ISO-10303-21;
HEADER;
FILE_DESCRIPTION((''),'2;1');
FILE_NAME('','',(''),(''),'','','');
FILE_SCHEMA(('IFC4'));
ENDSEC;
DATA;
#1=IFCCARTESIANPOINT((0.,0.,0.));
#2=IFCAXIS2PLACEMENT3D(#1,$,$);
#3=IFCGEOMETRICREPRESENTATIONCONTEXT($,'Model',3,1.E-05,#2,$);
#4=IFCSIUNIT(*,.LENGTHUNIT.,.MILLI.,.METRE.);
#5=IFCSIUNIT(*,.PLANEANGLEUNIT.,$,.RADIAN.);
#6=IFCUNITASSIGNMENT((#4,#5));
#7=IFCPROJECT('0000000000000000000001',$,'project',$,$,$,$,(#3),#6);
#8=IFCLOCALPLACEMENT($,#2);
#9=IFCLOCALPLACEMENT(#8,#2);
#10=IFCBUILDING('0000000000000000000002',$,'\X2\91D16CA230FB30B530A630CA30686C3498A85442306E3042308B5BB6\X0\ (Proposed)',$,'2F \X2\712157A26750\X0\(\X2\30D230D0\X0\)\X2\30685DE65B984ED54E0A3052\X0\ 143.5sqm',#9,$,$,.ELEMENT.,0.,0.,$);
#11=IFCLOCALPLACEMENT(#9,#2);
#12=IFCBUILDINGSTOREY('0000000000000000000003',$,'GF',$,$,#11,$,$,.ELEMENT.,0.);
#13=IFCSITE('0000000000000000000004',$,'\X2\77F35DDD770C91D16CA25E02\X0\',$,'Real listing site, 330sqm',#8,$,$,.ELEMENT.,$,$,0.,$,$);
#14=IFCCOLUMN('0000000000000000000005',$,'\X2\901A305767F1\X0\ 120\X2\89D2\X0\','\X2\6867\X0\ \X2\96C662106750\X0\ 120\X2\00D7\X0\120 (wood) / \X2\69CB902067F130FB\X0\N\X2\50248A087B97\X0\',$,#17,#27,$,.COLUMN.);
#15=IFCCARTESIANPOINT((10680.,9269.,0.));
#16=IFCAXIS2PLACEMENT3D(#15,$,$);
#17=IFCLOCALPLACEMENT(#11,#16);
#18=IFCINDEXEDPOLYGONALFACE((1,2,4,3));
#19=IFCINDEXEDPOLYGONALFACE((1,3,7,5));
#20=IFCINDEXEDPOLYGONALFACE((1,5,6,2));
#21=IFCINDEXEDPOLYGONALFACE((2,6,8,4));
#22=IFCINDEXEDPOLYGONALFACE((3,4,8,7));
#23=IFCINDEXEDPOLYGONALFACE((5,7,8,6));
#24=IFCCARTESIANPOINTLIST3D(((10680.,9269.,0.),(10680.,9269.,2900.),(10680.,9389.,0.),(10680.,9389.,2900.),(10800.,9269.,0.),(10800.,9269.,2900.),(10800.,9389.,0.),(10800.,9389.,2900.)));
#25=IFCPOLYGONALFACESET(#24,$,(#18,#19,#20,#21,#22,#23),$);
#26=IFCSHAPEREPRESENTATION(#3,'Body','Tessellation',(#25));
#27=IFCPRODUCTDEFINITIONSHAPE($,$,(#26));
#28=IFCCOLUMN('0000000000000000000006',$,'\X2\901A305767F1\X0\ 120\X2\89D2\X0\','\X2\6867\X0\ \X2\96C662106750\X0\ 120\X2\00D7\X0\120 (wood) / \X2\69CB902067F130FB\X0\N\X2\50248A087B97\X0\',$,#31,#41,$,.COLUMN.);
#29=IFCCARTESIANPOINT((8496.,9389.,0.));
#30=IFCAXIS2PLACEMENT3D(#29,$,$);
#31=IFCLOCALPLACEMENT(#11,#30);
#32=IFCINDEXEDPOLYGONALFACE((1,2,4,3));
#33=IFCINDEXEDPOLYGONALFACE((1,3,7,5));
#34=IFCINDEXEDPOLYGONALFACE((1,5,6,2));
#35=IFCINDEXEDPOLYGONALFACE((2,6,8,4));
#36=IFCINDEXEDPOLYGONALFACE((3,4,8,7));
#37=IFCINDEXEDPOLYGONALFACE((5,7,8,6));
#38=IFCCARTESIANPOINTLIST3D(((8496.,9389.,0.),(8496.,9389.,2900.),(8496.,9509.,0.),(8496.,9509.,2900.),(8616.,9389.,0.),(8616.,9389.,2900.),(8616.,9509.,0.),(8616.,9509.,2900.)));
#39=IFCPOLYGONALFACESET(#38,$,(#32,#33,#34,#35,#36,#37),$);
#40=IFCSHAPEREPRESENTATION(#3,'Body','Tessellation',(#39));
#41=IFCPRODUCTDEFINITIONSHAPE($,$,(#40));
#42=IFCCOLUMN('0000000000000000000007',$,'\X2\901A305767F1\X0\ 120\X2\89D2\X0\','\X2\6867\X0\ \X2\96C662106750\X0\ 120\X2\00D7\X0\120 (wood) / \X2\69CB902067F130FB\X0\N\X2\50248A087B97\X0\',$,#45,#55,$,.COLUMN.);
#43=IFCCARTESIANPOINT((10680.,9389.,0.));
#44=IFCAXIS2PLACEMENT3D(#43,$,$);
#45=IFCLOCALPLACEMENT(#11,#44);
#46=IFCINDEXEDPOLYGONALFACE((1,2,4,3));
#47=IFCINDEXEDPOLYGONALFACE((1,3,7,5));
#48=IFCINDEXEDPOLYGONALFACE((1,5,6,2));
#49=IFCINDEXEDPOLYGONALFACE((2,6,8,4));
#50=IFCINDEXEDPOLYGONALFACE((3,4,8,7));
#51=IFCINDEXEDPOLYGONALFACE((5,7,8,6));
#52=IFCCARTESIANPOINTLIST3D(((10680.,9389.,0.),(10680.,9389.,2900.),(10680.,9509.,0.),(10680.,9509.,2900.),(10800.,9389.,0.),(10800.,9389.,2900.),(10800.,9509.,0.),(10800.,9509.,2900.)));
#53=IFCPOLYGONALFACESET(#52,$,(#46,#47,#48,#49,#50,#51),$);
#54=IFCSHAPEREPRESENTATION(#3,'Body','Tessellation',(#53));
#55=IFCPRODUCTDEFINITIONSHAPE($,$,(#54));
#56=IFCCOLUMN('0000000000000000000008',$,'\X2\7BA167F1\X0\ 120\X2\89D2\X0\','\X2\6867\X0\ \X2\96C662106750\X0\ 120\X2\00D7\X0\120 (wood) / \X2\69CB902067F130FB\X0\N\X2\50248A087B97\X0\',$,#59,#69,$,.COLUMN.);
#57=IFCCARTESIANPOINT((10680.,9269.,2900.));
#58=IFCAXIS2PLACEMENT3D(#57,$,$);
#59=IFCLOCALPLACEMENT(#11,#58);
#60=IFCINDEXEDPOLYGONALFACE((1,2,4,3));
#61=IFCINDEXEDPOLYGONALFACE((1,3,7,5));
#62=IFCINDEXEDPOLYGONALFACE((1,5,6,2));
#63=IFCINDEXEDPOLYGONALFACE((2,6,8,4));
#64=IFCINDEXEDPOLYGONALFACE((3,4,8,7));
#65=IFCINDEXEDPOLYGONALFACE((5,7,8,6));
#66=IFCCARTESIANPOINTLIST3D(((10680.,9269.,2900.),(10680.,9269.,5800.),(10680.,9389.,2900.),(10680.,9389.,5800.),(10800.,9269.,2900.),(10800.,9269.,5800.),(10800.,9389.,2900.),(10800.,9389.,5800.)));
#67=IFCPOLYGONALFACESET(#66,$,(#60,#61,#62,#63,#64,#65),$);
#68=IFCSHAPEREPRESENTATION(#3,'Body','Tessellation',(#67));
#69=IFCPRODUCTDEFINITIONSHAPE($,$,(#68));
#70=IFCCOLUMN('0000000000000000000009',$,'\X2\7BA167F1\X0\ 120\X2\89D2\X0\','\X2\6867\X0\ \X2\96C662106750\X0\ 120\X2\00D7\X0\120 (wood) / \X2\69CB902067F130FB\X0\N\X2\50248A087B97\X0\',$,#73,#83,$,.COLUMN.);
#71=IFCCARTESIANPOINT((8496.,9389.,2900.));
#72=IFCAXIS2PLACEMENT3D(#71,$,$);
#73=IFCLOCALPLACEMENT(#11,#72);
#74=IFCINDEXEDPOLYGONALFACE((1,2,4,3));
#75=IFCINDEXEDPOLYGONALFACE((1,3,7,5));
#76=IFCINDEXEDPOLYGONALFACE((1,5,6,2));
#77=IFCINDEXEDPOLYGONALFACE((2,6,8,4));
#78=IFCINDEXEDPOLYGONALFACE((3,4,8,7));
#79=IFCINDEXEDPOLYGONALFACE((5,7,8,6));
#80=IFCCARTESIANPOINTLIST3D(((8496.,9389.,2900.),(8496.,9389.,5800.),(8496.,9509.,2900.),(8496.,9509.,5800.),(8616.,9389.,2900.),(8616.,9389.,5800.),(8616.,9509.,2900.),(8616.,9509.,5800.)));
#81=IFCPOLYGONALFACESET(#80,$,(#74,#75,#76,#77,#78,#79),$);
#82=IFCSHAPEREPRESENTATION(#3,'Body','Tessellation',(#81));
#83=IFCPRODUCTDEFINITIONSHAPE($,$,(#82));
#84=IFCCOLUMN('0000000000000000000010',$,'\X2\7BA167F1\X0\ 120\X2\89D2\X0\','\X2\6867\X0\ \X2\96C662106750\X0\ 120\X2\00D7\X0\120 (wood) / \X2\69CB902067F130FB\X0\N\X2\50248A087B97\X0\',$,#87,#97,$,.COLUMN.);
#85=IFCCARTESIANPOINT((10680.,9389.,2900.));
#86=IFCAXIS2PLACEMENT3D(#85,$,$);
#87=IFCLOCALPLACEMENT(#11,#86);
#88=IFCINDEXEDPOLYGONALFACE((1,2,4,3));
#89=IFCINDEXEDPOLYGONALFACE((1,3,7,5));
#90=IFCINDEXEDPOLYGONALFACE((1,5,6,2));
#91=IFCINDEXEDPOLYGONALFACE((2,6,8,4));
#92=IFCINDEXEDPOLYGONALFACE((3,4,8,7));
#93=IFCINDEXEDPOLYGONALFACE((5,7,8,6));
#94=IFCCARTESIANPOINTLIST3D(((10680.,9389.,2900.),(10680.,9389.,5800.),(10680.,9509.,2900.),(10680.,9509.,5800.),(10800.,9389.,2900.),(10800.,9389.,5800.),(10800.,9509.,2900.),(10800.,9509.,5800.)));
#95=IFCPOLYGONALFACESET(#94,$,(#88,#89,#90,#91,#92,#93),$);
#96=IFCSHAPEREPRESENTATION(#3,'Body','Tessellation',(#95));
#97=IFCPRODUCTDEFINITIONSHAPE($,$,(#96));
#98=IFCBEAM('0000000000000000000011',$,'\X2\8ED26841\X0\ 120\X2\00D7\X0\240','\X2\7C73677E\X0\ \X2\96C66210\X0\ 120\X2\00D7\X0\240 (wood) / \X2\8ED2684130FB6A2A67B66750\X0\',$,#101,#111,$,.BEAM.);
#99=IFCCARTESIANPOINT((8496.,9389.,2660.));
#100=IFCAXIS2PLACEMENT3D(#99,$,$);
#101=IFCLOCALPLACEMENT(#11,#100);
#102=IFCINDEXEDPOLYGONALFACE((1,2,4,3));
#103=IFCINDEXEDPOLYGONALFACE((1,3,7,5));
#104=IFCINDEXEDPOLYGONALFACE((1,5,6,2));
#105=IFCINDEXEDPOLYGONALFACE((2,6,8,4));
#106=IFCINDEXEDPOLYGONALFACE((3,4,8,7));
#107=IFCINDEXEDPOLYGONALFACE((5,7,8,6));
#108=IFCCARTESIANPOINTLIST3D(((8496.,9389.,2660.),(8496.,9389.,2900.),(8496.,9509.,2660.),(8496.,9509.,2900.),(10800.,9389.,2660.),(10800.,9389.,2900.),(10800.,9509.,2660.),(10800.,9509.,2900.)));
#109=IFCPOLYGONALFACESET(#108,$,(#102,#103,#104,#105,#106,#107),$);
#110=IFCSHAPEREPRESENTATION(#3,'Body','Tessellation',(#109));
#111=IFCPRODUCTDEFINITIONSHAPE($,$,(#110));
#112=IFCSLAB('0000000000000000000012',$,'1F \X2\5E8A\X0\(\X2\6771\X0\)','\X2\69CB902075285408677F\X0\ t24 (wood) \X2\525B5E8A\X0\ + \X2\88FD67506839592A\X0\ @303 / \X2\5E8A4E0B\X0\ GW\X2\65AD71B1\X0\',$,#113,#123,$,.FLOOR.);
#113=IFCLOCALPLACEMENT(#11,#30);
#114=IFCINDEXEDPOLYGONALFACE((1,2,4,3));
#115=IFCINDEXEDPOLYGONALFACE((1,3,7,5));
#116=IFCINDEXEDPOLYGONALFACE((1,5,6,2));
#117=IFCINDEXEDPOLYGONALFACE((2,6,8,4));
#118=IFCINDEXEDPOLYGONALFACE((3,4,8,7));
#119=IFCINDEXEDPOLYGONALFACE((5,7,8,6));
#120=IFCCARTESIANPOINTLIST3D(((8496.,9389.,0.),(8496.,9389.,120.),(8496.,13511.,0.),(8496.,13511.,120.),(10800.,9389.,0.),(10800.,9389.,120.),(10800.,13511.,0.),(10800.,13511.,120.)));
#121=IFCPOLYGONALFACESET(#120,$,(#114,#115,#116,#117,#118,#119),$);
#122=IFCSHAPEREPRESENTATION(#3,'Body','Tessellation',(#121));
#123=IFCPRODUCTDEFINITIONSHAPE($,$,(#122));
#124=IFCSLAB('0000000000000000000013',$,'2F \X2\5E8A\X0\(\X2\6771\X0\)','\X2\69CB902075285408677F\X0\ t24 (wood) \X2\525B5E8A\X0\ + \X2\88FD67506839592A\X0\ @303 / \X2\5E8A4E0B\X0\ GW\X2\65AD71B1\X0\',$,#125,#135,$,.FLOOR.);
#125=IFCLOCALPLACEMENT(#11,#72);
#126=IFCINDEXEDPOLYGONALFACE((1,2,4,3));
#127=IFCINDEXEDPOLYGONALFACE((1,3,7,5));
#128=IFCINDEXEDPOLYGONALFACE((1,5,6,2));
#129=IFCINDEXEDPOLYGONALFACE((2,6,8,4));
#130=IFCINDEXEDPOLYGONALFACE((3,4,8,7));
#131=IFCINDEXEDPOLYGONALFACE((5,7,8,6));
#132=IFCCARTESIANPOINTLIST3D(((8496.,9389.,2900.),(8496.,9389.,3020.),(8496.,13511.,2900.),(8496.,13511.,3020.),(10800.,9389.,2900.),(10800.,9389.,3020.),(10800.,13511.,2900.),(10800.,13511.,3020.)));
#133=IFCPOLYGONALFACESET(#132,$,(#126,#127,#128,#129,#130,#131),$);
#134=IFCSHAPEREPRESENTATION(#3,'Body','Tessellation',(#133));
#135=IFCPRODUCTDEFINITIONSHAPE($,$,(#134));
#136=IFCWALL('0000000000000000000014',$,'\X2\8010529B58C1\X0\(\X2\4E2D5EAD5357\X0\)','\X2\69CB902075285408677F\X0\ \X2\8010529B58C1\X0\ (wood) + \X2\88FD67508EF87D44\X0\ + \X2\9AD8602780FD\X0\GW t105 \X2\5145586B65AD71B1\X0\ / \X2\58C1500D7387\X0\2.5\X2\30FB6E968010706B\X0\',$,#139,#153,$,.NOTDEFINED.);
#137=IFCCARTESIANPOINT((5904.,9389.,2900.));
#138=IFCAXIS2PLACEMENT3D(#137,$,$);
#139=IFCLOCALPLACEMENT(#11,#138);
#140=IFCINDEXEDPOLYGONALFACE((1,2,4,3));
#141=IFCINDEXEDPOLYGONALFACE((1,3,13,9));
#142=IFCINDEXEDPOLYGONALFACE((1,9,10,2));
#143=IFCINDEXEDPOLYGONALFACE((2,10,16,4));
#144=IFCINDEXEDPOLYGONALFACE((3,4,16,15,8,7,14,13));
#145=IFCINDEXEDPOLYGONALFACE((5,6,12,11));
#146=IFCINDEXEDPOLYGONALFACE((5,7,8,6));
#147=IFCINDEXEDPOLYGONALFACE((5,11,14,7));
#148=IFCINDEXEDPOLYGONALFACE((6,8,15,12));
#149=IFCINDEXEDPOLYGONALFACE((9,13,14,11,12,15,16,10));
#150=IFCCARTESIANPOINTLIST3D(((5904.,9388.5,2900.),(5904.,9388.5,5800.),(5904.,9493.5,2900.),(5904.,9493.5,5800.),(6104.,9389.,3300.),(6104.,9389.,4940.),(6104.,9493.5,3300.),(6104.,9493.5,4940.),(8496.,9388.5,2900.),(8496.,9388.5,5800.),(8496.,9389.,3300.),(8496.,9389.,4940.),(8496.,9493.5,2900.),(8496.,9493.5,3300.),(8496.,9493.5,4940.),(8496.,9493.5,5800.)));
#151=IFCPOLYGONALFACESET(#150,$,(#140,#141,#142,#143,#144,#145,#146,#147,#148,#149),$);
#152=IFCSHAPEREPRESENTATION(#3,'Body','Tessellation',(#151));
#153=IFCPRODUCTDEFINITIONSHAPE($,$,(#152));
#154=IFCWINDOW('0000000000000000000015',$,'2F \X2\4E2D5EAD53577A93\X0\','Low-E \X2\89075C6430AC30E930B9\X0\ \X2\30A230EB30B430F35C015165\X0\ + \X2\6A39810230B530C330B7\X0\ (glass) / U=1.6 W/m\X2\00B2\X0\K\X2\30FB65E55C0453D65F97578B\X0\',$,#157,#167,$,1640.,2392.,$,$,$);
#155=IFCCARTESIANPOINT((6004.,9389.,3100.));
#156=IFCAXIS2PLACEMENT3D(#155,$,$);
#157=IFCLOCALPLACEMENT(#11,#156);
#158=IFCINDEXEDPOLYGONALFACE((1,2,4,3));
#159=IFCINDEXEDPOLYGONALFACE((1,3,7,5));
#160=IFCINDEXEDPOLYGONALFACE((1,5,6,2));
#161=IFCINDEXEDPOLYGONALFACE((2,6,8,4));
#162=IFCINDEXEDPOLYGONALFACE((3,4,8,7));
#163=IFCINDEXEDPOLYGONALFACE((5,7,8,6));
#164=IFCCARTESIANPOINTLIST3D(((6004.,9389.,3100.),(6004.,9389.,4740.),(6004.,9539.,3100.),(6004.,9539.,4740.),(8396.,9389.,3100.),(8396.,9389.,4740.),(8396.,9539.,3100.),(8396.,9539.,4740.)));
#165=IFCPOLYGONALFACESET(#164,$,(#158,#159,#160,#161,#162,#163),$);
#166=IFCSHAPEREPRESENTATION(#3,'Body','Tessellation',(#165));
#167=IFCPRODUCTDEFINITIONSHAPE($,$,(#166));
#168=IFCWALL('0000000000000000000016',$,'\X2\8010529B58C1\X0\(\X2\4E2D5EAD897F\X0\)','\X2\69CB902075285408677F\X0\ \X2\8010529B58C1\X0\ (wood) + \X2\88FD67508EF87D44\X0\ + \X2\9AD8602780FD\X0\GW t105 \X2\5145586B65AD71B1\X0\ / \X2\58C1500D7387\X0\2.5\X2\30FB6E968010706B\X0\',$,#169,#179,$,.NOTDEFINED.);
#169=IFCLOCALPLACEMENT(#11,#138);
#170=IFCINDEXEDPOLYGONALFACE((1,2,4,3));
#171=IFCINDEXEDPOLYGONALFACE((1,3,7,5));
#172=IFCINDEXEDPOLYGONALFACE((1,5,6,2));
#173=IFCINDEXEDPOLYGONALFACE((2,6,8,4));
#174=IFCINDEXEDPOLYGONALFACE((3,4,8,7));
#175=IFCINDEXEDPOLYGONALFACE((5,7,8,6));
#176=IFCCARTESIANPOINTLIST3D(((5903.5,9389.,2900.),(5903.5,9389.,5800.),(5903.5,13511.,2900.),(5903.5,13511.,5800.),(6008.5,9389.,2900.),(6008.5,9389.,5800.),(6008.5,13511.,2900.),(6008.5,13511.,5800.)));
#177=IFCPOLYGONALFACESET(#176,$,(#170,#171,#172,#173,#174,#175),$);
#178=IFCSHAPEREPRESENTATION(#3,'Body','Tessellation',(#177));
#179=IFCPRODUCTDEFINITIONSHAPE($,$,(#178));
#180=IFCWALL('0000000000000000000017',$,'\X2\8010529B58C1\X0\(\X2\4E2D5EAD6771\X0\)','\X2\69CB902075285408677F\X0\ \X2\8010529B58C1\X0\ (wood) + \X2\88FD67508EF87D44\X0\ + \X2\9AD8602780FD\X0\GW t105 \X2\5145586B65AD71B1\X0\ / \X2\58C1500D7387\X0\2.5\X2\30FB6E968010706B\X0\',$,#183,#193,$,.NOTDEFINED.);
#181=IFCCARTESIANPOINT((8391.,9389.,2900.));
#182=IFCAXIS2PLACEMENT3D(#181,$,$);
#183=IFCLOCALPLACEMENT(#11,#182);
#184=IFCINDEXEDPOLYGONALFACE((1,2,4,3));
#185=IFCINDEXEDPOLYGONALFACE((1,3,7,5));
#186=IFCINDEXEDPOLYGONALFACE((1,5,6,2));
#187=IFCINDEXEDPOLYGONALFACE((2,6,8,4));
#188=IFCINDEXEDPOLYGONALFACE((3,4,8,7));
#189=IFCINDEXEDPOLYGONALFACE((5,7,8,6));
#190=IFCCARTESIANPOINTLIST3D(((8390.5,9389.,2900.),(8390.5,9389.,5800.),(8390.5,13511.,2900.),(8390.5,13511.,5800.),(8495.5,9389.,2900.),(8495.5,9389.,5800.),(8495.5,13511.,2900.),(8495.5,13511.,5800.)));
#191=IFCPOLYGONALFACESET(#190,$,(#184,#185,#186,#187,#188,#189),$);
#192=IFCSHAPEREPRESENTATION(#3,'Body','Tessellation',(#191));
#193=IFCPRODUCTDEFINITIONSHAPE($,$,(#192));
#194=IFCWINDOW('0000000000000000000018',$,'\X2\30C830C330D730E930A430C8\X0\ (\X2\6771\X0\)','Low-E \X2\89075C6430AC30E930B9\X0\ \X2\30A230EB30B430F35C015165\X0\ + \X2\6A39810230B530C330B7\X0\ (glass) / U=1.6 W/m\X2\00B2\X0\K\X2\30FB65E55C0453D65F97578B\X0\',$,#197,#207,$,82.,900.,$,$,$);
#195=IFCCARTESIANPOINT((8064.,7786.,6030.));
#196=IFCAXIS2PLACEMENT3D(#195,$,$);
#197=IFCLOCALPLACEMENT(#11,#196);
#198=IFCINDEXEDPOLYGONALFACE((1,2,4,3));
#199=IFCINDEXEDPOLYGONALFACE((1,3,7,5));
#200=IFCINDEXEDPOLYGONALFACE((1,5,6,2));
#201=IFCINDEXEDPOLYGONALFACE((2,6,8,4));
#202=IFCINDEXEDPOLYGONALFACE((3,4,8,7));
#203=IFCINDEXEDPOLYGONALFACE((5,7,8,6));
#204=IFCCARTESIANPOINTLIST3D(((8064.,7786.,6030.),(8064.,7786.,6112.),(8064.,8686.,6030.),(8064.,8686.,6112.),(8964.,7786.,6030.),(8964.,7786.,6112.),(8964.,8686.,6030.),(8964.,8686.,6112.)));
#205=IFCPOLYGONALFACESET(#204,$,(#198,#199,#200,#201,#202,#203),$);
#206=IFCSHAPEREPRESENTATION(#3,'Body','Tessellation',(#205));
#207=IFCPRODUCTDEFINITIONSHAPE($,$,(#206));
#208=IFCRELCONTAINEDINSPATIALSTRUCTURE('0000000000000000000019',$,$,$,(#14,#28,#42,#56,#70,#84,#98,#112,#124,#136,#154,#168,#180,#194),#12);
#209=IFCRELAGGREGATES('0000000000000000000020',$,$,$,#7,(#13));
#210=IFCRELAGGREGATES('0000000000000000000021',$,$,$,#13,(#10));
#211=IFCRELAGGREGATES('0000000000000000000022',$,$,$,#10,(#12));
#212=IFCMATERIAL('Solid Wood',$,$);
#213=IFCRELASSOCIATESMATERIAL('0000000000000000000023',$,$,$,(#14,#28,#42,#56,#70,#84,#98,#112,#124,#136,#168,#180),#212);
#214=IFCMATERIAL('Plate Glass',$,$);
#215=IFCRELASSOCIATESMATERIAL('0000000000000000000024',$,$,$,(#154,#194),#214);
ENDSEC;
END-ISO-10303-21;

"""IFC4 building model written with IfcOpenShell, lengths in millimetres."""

from ifc_helpers import new_model, si_unit, frame, frame_2d, origin, place, context, project, spatial, rectangle, extrude, material, element, fill, save


model = new_model("IFC4")

# Units and contexts
model_context = context("Model", 3, precision=1e-05, world=origin())
ifc_project = project(units=[si_unit("LENGTHUNIT", "METRE", prefix="MILLI"), si_unit("PLANEANGLEUNIT", "RADIAN")], contexts=[model_context])

# Site, building, storey
site_placement = place(None, origin())
site = spatial("IfcSite", under=ifc_project, at=site_placement, Name="石川県金沢市", ObjectType="Real listing site, 330sqm", CompositionType="ELEMENT", RefElevation=0.0)
building_placement = place(site_placement, origin())
building = spatial("IfcBuilding", under=site, at=building_placement, Name="金沢・サウナと水風呂のある家 (Proposed)", ObjectType="2F 無垢材(ヒバ)と左官仕上げ 143.5sqm", CompositionType="ELEMENT", ElevationOfRefHeight=0.0, ElevationOfTerrain=0.0)
storey_placement = place(building_placement, origin())
storey = spatial("IfcBuildingStorey", under=building, at=storey_placement, Name="GF", CompositionType="ELEMENT", Elevation=0.0)

# Columns
ifc_material_1 = material(Name="Solid Wood")
column_1_placement = place(storey_placement, frame((10680.0, 9269.0, 0.0)))
element("IfcColumn", 1, at=column_1_placement, inside=storey, material=ifc_material_1, Name="通し柱 120角", Description="桧 集成材 120×120 (wood) / 構造柱・N値計算", PredefinedType="COLUMN", context=model_context, shape_type="SweptSolid", body=[
    extrude(rectangle(XDim=120.0, YDim=120.0, at=frame_2d((60.0, 60.0))), frame((10680.0, 9269.0, 0.0)), (0.0, 0.0, 1.0), 2900.0),
])
column_2_placement = place(storey_placement, frame((8496.0, 9389.0, 0.0)))
element("IfcColumn", 2, at=column_2_placement, inside=storey, material=ifc_material_1, Name="通し柱 120角", Description="桧 集成材 120×120 (wood) / 構造柱・N値計算", PredefinedType="COLUMN", context=model_context, shape_type="SweptSolid", body=[
    extrude(rectangle(XDim=120.0, YDim=120.0, at=frame_2d((60.0, 60.0))), frame((8496.0, 9389.0, 0.0)), (0.0, 0.0, 1.0), 2900.0),
])
column_3_placement = place(storey_placement, frame((10680.0, 9389.0, 0.0)))
element("IfcColumn", 3, at=column_3_placement, inside=storey, material=ifc_material_1, Name="通し柱 120角", Description="桧 集成材 120×120 (wood) / 構造柱・N値計算", PredefinedType="COLUMN", context=model_context, shape_type="SweptSolid", body=[
    extrude(rectangle(XDim=120.0, YDim=120.0, at=frame_2d((60.0, 60.0))), frame((10680.0, 9389.0, 0.0)), (0.0, 0.0, 1.0), 2900.0),
])
column_4_placement = place(storey_placement, frame((10680.0, 9269.0, 2900.0)))
element("IfcColumn", 4, at=column_4_placement, inside=storey, material=ifc_material_1, Name="管柱 120角", Description="桧 集成材 120×120 (wood) / 構造柱・N値計算", PredefinedType="COLUMN", context=model_context, shape_type="SweptSolid", body=[
    extrude(rectangle(XDim=120.0, YDim=120.0, at=frame_2d((60.0, 60.0))), frame((10680.0, 9269.0, 2900.0)), (0.0, 0.0, 1.0), 2900.0),
])
column_5_placement = place(storey_placement, frame((8496.0, 9389.0, 2900.0)))
element("IfcColumn", 5, at=column_5_placement, inside=storey, material=ifc_material_1, Name="管柱 120角", Description="桧 集成材 120×120 (wood) / 構造柱・N値計算", PredefinedType="COLUMN", context=model_context, shape_type="SweptSolid", body=[
    extrude(rectangle(XDim=120.0, YDim=120.0, at=frame_2d((60.0, 60.0))), frame((8496.0, 9389.0, 2900.0)), (0.0, 0.0, 1.0), 2900.0),
])
column_6_placement = place(storey_placement, frame((10680.0, 9389.0, 2900.0)))
element("IfcColumn", 6, at=column_6_placement, inside=storey, material=ifc_material_1, Name="管柱 120角", Description="桧 集成材 120×120 (wood) / 構造柱・N値計算", PredefinedType="COLUMN", context=model_context, shape_type="SweptSolid", body=[
    extrude(rectangle(XDim=120.0, YDim=120.0, at=frame_2d((60.0, 60.0))), frame((10680.0, 9389.0, 2900.0)), (0.0, 0.0, 1.0), 2900.0),
])

# Beam
beam_1_placement = place(storey_placement, frame((8496.0, 9389.0, 2660.0)))
element("IfcBeam", 7, at=beam_1_placement, inside=storey, material=ifc_material_1, Name="軒桁 120×240", Description="米松 集成 120×240 (wood) / 軒桁・横架材", PredefinedType="BEAM", context=model_context, shape_type="SweptSolid", body=[
    extrude(rectangle(XDim=2304.0, YDim=120.0, at=frame_2d((1152.0, 60.0))), frame((8496.0, 9389.0, 2660.0)), (0.0, 0.0, 1.0), 240.0),
])

# Slabs
slab_1_placement = place(storey_placement, frame((8496.0, 9389.0, 0.0)))
element("IfcSlab", 8, at=slab_1_placement, inside=storey, material=ifc_material_1, Name="1F 床(東)", Description="構造用合板 t24 (wood) 剛床 + 製材根太 @303 / 床下 GW断熱", PredefinedType="FLOOR", context=model_context, shape_type="SweptSolid", body=[
    extrude(rectangle(XDim=2304.0, YDim=4122.0, at=frame_2d((1152.0, 2061.0))), frame((8496.0, 9389.0, 0.0)), (0.0, 0.0, 1.0), 120.0),
])
slab_2_placement = place(storey_placement, frame((8496.0, 9389.0, 2900.0)))
element("IfcSlab", 9, at=slab_2_placement, inside=storey, material=ifc_material_1, Name="2F 床(東)", Description="構造用合板 t24 (wood) 剛床 + 製材根太 @303 / 床下 GW断熱", PredefinedType="FLOOR", context=model_context, shape_type="SweptSolid", body=[
    extrude(rectangle(XDim=2304.0, YDim=4122.0, at=frame_2d((1152.0, 2061.0))), frame((8496.0, 9389.0, 2900.0)), (0.0, 0.0, 1.0), 120.0),
])

# Wall, opening, window
wall_1_placement = place(storey_placement, frame((5904.0, 9389.0, 2900.0)))
wall_1 = element("IfcWall", 10, at=wall_1_placement, inside=storey, material=ifc_material_1, Name="耐力壁(中庭南)", Description="構造用合板 耐力壁 (wood) + 製材軸組 + 高性能GW t105 充填断熱 / 壁倍率2.5・準耐火", PredefinedType="NOTDEFINED", context=model_context, shape_type="SweptSolid", body=[
    extrude(rectangle(XDim=2592.0, YDim=105.0, at=frame_2d((1296.0, 52.0))), frame((5904.0, 9389.0, 2900.0)), (0.0, 0.0, 1.0), 2900.0),
])
opening_placement = place(storey_placement, frame((6004.0, 9389.0, 3100.0)))
opening = element("IfcOpeningElement", 11, at=opening_placement, cuts=wall_1, PredefinedType="NOTDEFINED", context=model_context, shape_type="SweptSolid", body=[
    extrude(rectangle(XDim=2392.0, YDim=150.0, at=frame_2d((1196.0, 75.0))), frame((6004.0, 9389.0, 3100.0)), (0.0, 0.0, 1.0), 1640.0),
])
ifc_material_2 = material(Name="Plate Glass")
window_1_placement = place(storey_placement, frame((6004.0, 9389.0, 3100.0)))
window_1 = element("IfcWindow", 12, at=window_1_placement, inside=storey, material=ifc_material_2, Name="2F 中庭南窓", Description="Low-E 複層ガラス アルゴン封入 + 樹脂サッシ (glass) / U=1.6 W/m²K・日射取得型", OverallHeight=1640.0, OverallWidth=2392.0, context=model_context, shape_type="SweptSolid", body=[
    extrude(rectangle(XDim=2392.0, YDim=150.0, at=frame_2d((1196.0, 75.0))), frame((6004.0, 9389.0, 3100.0)), (0.0, 0.0, 1.0), 1640.0),
])
fill(opening, window_1)

# Walls
wall_2_placement = place(storey_placement, frame((5904.0, 9389.0, 2900.0)))
element("IfcWall", 13, at=wall_2_placement, inside=storey, material=ifc_material_1, Name="耐力壁(中庭西)", Description="構造用合板 耐力壁 (wood) + 製材軸組 + 高性能GW t105 充填断熱 / 壁倍率2.5・準耐火", PredefinedType="NOTDEFINED", context=model_context, shape_type="SweptSolid", body=[
    extrude(rectangle(XDim=105.0, YDim=4122.0, at=frame_2d((52.0, 2061.0))), frame((5904.0, 9389.0, 2900.0)), (0.0, 0.0, 1.0), 2900.0),
])
wall_3_placement = place(storey_placement, frame((8391.0, 9389.0, 2900.0)))
element("IfcWall", 14, at=wall_3_placement, inside=storey, material=ifc_material_1, Name="耐力壁(中庭東)", Description="構造用合板 耐力壁 (wood) + 製材軸組 + 高性能GW t105 充填断熱 / 壁倍率2.5・準耐火", PredefinedType="NOTDEFINED", context=model_context, shape_type="SweptSolid", body=[
    extrude(rectangle(XDim=105.0, YDim=4122.0, at=frame_2d((52.0, 2061.0))), frame((8391.0, 9389.0, 2900.0)), (0.0, 0.0, 1.0), 2900.0),
])

# Window
window_2_placement = place(storey_placement, frame((8064.0, 7786.0, 6030.0)))
element("IfcWindow", 15, at=window_2_placement, inside=storey, material=ifc_material_2, Name="トップライト (東)", Description="Low-E 複層ガラス アルゴン封入 + 樹脂サッシ (glass) / U=1.6 W/m²K・日射取得型", OverallHeight=82.0, OverallWidth=900.0, context=model_context, shape_type="SweptSolid", body=[
    extrude(rectangle(XDim=900.0, YDim=900.0, at=frame_2d((450.0, 450.0))), frame((8064.0, 7786.0, 6030.0)), (0.0, 0.0, 1.0), 82.0),
])

save(model, "model.ifc")
